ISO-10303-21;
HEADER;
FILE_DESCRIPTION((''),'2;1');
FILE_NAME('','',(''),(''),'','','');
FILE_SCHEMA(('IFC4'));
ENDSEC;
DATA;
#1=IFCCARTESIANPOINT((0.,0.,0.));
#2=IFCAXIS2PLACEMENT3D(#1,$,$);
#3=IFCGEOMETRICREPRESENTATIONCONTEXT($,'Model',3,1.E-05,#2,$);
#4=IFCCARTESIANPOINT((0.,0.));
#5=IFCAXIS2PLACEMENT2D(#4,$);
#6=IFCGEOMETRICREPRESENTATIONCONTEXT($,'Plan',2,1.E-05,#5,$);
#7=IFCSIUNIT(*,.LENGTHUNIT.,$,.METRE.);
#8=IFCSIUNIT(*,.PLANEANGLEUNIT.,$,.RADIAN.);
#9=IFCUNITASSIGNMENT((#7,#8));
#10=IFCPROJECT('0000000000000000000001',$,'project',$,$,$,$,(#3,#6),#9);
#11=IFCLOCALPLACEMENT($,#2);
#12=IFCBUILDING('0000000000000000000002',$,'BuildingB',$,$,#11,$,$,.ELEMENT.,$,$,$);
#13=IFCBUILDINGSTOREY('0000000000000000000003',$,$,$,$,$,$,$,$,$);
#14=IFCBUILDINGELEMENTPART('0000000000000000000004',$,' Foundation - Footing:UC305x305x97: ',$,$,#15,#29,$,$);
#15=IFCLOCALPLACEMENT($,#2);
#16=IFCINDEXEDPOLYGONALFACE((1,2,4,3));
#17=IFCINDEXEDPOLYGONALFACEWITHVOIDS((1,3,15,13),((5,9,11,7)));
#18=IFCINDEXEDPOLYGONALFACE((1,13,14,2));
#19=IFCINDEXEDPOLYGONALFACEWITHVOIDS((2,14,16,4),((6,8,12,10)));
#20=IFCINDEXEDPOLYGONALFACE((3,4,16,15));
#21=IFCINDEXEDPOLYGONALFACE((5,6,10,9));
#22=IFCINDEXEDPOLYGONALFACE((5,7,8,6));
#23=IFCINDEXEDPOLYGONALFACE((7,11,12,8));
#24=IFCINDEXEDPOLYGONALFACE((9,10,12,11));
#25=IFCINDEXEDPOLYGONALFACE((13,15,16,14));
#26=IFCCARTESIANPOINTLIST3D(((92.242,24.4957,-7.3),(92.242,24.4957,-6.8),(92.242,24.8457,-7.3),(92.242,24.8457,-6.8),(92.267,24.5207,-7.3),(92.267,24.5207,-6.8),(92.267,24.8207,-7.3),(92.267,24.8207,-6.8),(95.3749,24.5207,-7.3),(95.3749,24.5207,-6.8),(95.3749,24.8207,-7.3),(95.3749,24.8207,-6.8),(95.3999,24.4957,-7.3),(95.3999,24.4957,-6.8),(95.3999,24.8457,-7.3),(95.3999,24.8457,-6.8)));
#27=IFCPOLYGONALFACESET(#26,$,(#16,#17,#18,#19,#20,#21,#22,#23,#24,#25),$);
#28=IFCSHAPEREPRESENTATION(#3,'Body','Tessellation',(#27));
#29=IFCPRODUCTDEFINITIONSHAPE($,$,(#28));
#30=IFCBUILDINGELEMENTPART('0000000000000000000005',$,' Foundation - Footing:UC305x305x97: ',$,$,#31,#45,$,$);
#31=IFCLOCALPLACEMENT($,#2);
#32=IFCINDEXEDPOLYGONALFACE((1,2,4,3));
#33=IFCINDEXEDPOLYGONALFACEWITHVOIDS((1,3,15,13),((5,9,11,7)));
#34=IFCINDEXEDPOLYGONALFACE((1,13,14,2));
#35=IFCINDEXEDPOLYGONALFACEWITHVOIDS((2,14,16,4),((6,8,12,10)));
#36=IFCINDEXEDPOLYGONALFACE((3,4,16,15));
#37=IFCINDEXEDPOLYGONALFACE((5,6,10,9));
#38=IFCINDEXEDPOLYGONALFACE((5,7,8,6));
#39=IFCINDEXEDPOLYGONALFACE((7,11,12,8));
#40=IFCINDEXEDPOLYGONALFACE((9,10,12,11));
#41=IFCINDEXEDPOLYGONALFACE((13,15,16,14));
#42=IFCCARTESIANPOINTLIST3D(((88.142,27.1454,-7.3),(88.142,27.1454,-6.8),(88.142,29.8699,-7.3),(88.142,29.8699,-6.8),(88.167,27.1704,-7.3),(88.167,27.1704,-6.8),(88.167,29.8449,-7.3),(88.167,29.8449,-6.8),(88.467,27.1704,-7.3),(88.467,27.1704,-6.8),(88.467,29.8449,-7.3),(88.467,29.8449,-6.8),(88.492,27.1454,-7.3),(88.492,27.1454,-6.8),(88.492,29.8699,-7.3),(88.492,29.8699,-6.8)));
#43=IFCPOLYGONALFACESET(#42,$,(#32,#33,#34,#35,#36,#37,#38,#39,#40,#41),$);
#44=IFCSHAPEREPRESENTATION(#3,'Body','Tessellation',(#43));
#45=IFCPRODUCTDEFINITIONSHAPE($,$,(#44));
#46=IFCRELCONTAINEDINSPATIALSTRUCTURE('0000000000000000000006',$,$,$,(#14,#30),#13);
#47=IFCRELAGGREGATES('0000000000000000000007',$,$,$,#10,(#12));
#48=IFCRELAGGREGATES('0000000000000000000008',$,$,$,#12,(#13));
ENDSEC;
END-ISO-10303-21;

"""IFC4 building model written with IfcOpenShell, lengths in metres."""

from ifc_helpers import new_model, si_unit, origin, origin_2d, place, context, project, spatial, polyline, outline, extrude, element, save


model = new_model("IFC4")

# Units and contexts
model_context = context("Model", 3, precision=1e-05, world=origin())
plan_context = context("Plan", 2, precision=1e-05, world=origin_2d())
ifc_project = project(units=[si_unit("LENGTHUNIT", "METRE"), si_unit("PLANEANGLEUNIT", "RADIAN")], contexts=[model_context, plan_context])

# Building, storey
building_placement = place(None, origin())
building = spatial("IfcBuilding", under=ifc_project, at=building_placement, Name="BuildingB", CompositionType="ELEMENT")
storey = spatial("IfcBuildingStorey", under=building)

# Building element parts, openings
building_element_part_1 = element("IfcBuildingElementPart", 1, inside=storey, Name=" Foundation - Footing:UC305x305x97: ", context=model_context, shape_type="SweptSolid", body=[
    extrude(outline(polyline([(95.3999, 24.4957, -7.3), (95.3999, 24.8457, -7.3), (92.242, 24.8457, -7.3), (92.242, 24.4957, -7.3), (95.3999, 24.4957, -7.3)])), None, (0.0, 0.0, 1.0), 0.5),
])
element("IfcOpeningElement", 2, inside=storey, cuts=building_element_part_1, context=model_context, shape_type="SweptSolid", body=[
    extrude(outline(polyline([(95.3749, 24.5207, -7.3), (95.3749, 24.8207, -7.3), (92.267, 24.8207, -7.3), (92.267, 24.5207, -7.3), (95.3749, 24.5207, -7.3)])), None, (0.0, 0.0, 1.0), 0.5),
])
building_element_part_2 = element("IfcBuildingElementPart", 3, inside=storey, Name=" Foundation - Footing:UC305x305x97: ", context=model_context, shape_type="SweptSolid", body=[
    extrude(outline(polyline([(88.492, 27.1454, -7.3), (88.142, 27.1454, -7.3), (88.142, 29.8699, -7.3), (88.492, 29.8699, -7.3), (88.492, 27.1454, -7.3)])), None, (0.0, 0.0, 1.0), 0.5),
])
element("IfcOpeningElement", 4, inside=storey, cuts=building_element_part_2, context=model_context, shape_type="SweptSolid", body=[
    extrude(outline(polyline([(88.467, 27.1704, -7.3), (88.167, 27.1704, -7.3), (88.167, 29.8449, -7.3), (88.467, 29.8449, -7.3), (88.467, 27.1704, -7.3)])), None, (0.0, 0.0, 1.0), 0.5),
])

save(model, "model.ifc")
